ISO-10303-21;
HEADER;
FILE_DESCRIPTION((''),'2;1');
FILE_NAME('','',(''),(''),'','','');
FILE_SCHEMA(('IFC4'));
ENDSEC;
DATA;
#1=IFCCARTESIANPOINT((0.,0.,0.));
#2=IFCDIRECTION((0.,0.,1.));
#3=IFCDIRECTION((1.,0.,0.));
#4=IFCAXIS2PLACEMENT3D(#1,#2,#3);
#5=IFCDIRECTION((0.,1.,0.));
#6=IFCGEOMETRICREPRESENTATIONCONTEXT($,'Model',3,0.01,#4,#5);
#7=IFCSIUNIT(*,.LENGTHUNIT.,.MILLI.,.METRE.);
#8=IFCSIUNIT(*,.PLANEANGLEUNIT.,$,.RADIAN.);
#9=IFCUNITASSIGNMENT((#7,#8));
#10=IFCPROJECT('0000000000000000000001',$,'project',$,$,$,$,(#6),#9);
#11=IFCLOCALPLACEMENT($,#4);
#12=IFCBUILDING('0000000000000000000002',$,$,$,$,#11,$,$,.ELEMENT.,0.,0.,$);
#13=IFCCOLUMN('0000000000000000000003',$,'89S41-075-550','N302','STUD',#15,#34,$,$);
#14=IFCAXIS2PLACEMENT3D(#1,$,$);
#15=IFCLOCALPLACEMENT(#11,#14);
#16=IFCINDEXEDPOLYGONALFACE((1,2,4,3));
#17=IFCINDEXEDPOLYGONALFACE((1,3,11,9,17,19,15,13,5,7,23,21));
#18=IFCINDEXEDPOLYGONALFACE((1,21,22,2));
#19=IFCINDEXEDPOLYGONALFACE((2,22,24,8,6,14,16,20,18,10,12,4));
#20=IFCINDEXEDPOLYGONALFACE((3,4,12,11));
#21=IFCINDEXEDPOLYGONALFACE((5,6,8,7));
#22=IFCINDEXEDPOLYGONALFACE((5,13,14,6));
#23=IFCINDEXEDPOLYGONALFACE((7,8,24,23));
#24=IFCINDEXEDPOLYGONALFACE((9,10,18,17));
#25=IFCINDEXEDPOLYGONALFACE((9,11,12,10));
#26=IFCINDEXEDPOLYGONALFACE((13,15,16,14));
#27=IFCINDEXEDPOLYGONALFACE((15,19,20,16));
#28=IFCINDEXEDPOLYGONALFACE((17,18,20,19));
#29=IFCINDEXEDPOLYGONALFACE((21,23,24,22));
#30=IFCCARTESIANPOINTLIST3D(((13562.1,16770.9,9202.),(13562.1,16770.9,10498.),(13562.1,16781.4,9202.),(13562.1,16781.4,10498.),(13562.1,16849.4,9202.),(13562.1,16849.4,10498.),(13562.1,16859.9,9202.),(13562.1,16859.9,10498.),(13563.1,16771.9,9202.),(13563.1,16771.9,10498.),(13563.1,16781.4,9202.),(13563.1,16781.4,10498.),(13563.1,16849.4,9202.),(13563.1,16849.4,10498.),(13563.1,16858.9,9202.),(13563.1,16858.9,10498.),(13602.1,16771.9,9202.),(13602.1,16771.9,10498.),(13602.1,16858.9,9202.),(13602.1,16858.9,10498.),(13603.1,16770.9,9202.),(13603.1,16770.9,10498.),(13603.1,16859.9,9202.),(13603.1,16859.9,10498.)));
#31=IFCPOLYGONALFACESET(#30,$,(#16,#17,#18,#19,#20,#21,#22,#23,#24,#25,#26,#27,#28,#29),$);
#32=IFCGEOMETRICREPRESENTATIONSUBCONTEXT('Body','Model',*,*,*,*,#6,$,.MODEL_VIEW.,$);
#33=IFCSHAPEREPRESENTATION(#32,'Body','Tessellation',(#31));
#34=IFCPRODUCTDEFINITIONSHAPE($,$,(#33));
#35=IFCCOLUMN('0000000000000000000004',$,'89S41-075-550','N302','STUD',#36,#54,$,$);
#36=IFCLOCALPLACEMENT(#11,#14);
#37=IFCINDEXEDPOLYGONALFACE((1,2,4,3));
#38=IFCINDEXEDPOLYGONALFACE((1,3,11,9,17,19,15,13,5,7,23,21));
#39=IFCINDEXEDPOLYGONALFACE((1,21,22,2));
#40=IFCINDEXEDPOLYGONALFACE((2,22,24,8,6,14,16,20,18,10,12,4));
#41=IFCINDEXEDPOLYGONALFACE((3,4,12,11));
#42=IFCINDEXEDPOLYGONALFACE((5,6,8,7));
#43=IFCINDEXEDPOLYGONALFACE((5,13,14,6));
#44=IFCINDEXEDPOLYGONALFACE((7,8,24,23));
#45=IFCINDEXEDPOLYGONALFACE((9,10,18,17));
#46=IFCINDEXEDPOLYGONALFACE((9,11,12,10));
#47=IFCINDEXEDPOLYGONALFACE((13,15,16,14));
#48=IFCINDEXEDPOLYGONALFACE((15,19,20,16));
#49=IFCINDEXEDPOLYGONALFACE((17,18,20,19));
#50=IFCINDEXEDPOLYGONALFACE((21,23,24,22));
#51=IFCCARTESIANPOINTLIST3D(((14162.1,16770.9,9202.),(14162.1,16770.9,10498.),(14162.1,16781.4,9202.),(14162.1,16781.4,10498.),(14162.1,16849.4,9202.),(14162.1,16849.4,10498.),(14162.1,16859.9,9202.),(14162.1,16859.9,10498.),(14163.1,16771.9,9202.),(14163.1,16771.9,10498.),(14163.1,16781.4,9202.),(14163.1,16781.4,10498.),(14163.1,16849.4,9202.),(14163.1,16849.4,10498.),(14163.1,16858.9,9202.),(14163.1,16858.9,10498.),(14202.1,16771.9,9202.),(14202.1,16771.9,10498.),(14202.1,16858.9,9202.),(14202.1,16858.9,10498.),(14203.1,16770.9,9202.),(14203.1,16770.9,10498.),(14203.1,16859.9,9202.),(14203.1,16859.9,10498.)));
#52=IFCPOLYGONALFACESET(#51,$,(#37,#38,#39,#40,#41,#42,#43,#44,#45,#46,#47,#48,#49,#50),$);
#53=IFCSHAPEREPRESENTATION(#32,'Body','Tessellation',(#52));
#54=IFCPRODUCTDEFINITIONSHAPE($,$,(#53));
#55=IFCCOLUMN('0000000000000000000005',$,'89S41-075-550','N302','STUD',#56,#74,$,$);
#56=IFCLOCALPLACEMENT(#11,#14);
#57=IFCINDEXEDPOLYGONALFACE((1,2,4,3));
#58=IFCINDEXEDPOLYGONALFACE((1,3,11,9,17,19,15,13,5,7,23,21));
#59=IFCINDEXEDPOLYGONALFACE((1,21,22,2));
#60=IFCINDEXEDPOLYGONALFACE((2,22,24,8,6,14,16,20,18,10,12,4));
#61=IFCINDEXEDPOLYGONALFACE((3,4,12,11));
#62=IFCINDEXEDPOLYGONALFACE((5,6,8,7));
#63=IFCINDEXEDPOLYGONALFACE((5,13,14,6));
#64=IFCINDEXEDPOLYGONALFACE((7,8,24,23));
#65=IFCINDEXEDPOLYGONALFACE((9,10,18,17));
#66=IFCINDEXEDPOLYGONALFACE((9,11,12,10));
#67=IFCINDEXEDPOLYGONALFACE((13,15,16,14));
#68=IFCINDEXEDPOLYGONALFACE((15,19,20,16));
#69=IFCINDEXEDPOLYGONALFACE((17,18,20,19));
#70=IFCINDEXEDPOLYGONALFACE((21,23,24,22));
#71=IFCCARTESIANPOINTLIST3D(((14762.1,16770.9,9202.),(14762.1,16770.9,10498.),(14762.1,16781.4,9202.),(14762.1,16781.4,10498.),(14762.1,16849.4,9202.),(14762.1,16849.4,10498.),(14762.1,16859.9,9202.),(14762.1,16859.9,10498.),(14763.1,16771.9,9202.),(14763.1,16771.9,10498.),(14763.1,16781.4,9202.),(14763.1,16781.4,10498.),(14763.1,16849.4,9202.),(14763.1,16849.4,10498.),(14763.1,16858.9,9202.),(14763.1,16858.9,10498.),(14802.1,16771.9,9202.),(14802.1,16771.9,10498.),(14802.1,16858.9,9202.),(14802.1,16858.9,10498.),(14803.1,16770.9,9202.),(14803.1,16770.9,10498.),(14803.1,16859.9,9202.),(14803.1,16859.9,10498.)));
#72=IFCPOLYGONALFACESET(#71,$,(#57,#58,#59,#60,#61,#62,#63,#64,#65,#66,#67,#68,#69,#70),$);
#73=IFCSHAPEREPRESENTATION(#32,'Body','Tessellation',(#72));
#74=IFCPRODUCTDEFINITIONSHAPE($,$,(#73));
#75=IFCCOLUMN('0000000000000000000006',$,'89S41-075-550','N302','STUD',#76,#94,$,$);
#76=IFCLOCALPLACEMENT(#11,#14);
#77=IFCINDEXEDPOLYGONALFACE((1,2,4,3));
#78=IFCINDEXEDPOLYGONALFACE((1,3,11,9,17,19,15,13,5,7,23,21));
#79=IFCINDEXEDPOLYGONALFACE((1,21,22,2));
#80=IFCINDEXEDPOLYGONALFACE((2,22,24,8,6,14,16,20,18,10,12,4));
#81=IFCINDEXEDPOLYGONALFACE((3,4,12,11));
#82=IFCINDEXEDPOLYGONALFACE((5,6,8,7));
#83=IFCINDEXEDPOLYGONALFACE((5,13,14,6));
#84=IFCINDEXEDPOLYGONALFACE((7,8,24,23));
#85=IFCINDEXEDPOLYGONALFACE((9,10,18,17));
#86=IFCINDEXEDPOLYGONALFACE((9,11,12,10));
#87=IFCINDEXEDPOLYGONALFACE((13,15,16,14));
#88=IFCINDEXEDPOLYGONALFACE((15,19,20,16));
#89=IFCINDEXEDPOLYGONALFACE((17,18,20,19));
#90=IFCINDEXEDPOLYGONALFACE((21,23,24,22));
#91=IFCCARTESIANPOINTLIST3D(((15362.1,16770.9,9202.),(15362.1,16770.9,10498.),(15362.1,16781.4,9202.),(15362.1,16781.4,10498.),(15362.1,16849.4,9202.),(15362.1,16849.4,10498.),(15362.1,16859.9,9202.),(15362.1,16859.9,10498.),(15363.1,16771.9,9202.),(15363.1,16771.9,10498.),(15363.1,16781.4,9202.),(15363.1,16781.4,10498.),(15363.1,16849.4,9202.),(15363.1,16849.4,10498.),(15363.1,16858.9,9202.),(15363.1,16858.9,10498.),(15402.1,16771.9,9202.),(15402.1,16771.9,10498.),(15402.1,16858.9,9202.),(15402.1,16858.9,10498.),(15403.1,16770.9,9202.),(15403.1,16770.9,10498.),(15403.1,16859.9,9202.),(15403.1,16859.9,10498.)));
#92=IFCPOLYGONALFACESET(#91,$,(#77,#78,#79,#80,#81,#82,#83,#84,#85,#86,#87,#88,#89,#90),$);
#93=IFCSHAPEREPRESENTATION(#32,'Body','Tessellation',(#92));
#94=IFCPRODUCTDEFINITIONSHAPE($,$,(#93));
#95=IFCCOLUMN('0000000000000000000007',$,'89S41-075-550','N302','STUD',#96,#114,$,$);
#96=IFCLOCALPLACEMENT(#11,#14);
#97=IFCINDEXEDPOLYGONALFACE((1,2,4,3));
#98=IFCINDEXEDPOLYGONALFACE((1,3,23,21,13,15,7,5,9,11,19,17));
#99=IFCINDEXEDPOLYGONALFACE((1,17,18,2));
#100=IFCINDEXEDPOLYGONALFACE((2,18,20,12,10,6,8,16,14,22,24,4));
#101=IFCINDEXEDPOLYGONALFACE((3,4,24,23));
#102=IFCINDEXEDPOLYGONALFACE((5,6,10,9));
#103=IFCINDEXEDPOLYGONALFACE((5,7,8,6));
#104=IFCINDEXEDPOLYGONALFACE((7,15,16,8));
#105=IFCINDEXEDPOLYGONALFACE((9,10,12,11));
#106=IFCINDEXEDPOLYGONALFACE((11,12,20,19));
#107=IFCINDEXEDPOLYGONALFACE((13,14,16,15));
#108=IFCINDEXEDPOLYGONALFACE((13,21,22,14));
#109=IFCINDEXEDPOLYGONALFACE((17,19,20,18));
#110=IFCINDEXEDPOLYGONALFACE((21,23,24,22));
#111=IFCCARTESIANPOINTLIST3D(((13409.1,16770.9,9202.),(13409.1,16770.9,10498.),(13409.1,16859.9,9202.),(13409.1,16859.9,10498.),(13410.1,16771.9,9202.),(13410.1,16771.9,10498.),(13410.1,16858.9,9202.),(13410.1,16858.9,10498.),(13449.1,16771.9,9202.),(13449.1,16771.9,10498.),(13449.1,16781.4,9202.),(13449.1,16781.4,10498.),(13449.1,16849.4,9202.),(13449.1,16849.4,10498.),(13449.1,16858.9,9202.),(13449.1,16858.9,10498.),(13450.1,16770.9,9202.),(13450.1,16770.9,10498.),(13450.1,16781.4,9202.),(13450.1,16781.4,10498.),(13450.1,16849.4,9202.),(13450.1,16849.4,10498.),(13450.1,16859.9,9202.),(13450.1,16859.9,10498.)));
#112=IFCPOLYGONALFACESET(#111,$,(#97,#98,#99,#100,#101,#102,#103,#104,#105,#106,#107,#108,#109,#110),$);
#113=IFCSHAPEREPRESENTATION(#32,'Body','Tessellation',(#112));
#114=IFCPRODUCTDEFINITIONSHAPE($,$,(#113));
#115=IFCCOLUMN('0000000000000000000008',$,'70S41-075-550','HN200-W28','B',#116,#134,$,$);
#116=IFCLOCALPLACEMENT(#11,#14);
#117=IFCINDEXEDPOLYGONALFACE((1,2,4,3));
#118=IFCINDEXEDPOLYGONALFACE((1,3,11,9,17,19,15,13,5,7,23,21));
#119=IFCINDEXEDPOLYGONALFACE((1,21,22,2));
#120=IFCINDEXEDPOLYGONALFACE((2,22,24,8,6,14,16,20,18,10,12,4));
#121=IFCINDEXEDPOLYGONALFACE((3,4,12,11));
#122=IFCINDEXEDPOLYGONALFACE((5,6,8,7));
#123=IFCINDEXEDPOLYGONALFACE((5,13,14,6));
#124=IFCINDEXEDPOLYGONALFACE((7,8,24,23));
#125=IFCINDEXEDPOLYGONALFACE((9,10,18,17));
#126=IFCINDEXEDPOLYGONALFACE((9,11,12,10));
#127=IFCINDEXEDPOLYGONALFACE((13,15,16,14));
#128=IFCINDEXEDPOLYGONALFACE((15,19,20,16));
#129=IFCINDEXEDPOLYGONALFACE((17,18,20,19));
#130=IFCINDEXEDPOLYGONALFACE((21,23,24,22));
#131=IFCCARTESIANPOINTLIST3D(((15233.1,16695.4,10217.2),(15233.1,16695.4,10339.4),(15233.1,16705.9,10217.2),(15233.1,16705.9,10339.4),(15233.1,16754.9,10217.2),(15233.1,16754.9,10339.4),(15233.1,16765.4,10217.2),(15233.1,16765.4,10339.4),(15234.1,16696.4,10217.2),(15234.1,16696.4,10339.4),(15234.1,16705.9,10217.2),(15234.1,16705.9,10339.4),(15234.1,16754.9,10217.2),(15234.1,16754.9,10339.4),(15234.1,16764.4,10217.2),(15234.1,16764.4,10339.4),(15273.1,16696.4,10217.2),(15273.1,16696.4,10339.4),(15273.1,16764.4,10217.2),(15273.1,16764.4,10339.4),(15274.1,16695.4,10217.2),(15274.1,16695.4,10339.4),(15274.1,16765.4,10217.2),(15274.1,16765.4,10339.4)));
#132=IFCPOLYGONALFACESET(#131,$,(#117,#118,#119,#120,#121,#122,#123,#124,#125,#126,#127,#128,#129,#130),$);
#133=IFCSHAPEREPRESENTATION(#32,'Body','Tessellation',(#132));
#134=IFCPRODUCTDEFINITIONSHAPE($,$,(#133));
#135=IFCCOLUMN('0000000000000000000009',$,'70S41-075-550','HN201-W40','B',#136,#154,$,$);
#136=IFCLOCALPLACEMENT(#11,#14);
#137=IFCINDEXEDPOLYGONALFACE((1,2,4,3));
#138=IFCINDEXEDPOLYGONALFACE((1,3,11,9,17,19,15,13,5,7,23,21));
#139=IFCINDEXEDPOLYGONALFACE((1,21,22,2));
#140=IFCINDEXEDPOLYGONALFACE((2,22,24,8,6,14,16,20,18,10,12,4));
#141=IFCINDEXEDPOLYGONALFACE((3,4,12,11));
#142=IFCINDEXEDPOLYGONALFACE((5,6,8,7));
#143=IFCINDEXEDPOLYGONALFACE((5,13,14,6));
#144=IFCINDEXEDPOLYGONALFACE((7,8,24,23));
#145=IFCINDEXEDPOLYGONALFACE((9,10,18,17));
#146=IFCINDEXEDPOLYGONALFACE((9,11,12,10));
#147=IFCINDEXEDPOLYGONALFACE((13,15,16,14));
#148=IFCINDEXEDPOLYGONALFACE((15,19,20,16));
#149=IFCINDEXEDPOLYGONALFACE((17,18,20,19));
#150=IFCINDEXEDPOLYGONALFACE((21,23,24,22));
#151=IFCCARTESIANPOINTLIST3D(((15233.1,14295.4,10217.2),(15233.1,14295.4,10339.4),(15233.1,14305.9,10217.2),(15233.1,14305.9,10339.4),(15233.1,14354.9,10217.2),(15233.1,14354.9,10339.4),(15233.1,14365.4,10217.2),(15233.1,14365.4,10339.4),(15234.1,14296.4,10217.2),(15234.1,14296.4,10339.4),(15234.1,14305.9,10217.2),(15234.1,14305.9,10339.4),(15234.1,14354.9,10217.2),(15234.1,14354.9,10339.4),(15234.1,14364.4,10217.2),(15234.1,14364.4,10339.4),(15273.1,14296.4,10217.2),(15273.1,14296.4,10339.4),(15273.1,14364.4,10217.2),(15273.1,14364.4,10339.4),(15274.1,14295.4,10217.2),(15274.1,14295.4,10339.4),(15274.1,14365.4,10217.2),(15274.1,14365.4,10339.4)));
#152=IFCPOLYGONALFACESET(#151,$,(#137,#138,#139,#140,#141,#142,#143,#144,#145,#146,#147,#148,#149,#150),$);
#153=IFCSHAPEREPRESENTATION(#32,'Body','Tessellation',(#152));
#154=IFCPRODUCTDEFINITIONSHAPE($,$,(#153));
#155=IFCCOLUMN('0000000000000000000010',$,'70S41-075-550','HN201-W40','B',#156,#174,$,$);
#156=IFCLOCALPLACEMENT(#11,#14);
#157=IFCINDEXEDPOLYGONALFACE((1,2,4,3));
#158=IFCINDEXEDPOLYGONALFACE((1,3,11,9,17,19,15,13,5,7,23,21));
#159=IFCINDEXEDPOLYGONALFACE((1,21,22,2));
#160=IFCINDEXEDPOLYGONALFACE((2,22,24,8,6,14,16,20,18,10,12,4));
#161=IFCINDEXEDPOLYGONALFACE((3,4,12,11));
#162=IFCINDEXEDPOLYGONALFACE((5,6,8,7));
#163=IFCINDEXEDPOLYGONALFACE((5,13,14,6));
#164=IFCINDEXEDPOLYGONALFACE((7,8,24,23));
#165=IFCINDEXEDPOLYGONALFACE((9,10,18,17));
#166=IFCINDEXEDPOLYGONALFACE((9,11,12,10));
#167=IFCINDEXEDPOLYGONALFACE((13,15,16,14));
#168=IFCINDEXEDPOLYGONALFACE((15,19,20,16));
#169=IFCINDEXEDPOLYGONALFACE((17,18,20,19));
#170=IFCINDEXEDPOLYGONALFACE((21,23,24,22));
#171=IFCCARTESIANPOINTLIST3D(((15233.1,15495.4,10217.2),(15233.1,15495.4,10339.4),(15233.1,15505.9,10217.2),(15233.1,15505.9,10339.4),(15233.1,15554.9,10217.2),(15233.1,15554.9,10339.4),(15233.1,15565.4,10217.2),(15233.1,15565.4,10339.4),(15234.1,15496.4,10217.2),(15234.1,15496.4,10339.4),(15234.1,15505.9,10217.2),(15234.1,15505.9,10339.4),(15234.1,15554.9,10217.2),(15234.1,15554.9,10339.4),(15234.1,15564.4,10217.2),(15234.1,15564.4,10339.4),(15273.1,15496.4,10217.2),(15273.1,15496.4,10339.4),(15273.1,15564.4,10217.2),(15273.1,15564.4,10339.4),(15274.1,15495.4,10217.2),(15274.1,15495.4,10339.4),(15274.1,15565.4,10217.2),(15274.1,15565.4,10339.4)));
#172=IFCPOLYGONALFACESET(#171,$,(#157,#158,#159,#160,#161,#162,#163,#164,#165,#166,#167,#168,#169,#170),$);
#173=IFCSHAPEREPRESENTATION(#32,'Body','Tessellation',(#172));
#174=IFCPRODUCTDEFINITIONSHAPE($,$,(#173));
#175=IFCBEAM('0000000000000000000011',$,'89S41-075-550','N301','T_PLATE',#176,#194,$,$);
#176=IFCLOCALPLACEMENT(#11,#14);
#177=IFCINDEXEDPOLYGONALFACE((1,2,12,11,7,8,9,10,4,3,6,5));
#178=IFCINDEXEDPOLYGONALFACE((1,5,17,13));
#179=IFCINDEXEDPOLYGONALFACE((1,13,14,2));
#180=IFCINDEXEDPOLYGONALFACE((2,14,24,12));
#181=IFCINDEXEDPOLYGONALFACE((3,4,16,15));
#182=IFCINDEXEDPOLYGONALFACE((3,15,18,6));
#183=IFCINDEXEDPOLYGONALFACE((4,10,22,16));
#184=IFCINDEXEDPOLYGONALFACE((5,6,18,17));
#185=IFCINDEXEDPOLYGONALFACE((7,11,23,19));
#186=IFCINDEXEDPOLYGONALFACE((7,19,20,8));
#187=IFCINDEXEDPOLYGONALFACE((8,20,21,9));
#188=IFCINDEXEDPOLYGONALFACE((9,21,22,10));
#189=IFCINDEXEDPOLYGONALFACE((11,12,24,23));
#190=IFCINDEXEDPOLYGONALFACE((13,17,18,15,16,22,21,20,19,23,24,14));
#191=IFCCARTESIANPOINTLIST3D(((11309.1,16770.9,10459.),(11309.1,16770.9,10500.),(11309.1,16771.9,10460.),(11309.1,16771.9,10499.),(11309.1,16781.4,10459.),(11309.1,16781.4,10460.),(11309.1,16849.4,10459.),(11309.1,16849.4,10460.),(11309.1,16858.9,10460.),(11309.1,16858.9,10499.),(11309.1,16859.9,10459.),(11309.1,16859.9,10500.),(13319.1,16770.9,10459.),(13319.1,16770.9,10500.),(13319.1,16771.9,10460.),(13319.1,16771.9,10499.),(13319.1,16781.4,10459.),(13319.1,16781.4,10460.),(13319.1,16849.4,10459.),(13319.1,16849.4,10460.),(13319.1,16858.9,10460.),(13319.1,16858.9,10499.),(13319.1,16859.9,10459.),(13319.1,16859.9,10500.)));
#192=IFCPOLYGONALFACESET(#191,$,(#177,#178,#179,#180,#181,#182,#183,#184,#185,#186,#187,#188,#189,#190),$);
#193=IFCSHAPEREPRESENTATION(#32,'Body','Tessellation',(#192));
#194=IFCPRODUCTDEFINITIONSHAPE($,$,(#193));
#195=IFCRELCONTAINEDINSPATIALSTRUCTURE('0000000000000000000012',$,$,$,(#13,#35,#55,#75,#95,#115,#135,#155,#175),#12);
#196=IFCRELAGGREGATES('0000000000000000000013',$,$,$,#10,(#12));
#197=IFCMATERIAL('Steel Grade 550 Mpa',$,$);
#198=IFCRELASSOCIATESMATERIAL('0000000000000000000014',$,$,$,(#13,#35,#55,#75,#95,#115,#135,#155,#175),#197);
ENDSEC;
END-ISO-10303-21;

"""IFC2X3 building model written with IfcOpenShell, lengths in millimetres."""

from ifc_helpers import new_model, si_unit, direction, frame, origin, origin_with_axes, origin_2d_with_axis, place, context, subcontext, project, spatial, c_section, extrude, source, transform, mapped, material, element, save


model = new_model("IFC2X3")

# Units and contexts
model_context = context("Model", 3, precision=0.01, world=origin_with_axes(), true_north=direction((0.0, 1.0, 0.0)))
body_context = subcontext(model_context, "Body", "Model", "MODEL_VIEW")
ifc_project = project(units=[si_unit("LENGTHUNIT", "METRE", prefix="MILLI"), si_unit("PLANEANGLEUNIT", "RADIAN")], contexts=[model_context])

# Building
building_placement = place(None, origin_with_axes())
building = spatial("IfcBuilding", under=ifc_project, at=building_placement, CompositionType="ELEMENT", ElevationOfRefHeight=0.0, ElevationOfTerrain=0.0)

# Columns
ifc_material = material(Name="Steel Grade 550 Mpa")
shared_shape_1 = source(origin(), body_context, "Body", "SweptSolid", [
    extrude(c_section(Depth=89.0, Width=41.0, WallThickness=1.0, Girth=10.5, at=origin_2d_with_axis()), origin_with_axes(), (0.0, 0.0, 1.0), 1296.0),
])
column_1_placement = place(None, frame((13582.6, 16815.4, 9202.0), z_axis=(0.0, 0.0, 1.0), x_axis=(-1.0, 0.0, 0.0)))
element("IfcColumn", 1, at=column_1_placement, inside=building, material=ifc_material, Name="89S41-075-550", Description="N302", ObjectType="STUD", context=body_context, shape_type="MappedRepresentation", body=[
    mapped(shared_shape_1, transform((0.0, 0.0, 0.0), scale=1.0)),
])
shared_shape_2 = source(origin(), body_context, "Body", "SweptSolid", [
    extrude(c_section(Depth=89.0, Width=41.0, WallThickness=1.0, Girth=10.5, at=origin_2d_with_axis()), origin_with_axes(), (0.0, 0.0, 1.0), 1296.0),
])
column_2_placement = place(None, frame((14182.6, 16815.4, 9202.0), z_axis=(0.0, 0.0, 1.0), x_axis=(-1.0, 0.0, 0.0)))
element("IfcColumn", 2, at=column_2_placement, inside=building, material=ifc_material, Name="89S41-075-550", Description="N302", ObjectType="STUD", context=body_context, shape_type="MappedRepresentation", body=[
    mapped(shared_shape_2, transform((0.0, 0.0, 0.0), scale=1.0)),
])
shared_shape_3 = source(origin(), body_context, "Body", "SweptSolid", [
    extrude(c_section(Depth=89.0, Width=41.0, WallThickness=1.0, Girth=10.5, at=origin_2d_with_axis()), origin_with_axes(), (0.0, 0.0, 1.0), 1296.0),
])
column_3_placement = place(None, frame((14782.6, 16815.4, 9202.0), z_axis=(0.0, 0.0, 1.0), x_axis=(-1.0, 0.0, 0.0)))
element("IfcColumn", 3, at=column_3_placement, inside=building, material=ifc_material, Name="89S41-075-550", Description="N302", ObjectType="STUD", context=body_context, shape_type="MappedRepresentation", body=[
    mapped(shared_shape_3, transform((0.0, 0.0, 0.0), scale=1.0)),
])
shared_shape_4 = source(origin(), body_context, "Body", "SweptSolid", [
    extrude(c_section(Depth=89.0, Width=41.0, WallThickness=1.0, Girth=10.5, at=origin_2d_with_axis()), origin_with_axes(), (0.0, 0.0, 1.0), 1296.0),
])
column_4_placement = place(None, frame((15382.6, 16815.4, 9202.0), z_axis=(0.0, 0.0, 1.0), x_axis=(-1.0, 0.0, 0.0)))
element("IfcColumn", 4, at=column_4_placement, inside=building, material=ifc_material, Name="89S41-075-550", Description="N302", ObjectType="STUD", context=body_context, shape_type="MappedRepresentation", body=[
    mapped(shared_shape_4, transform((0.0, 0.0, 0.0), scale=1.0)),
])
shared_shape_5 = source(origin(), body_context, "Body", "SweptSolid", [
    extrude(c_section(Depth=89.0, Width=41.0, WallThickness=1.0, Girth=10.5, at=origin_2d_with_axis()), origin_with_axes(), (0.0, 0.0, 1.0), 1296.0),
])
column_5_placement = place(None, frame((13429.6, 16815.4, 9202.0), z_axis=(0.0, 0.0, 1.0), x_axis=(1.0, 0.0, 0.0)))
element("IfcColumn", 5, at=column_5_placement, inside=building, material=ifc_material, Name="89S41-075-550", Description="N302", ObjectType="STUD", context=body_context, shape_type="MappedRepresentation", body=[
    mapped(shared_shape_5, transform((0.0, 0.0, 0.0), scale=1.0)),
])
shared_shape_6 = source(origin(), body_context, "Body", "SweptSolid", [
    extrude(c_section(Depth=70.0, Width=41.0, WallThickness=1.0, Girth=10.5, at=origin_2d_with_axis()), origin_with_axes(), (0.0, 0.0, 1.0), 122.1),
])
column_6_placement = place(None, frame((15253.6, 16730.4, 10339.4), z_axis=(0.0, 0.0, -1.0), x_axis=(-1.0, 0.0, 0.0)))
element("IfcColumn", 6, at=column_6_placement, inside=building, material=ifc_material, Name="70S41-075-550", Description="HN200-W28", ObjectType="B", context=body_context, shape_type="MappedRepresentation", body=[
    mapped(shared_shape_6, transform((0.0, 0.0, 0.0), scale=1.0)),
])
shared_shape_7 = source(origin(), body_context, "Body", "SweptSolid", [
    extrude(c_section(Depth=70.0, Width=41.0, WallThickness=1.0, Girth=10.5, at=origin_2d_with_axis()), origin_with_axes(), (0.0, 0.0, 1.0), 122.1),
])
column_7_placement = place(None, frame((15253.6, 14330.4, 10339.4), z_axis=(0.0, 0.0, -1.0), x_axis=(-1.0, 0.0, 0.0)))
element("IfcColumn", 7, at=column_7_placement, inside=building, material=ifc_material, Name="70S41-075-550", Description="HN201-W40", ObjectType="B", context=body_context, shape_type="MappedRepresentation", body=[
    mapped(shared_shape_7, transform((0.0, 0.0, 0.0), scale=1.0)),
])
shared_shape_8 = source(origin(), body_context, "Body", "SweptSolid", [
    extrude(c_section(Depth=70.0, Width=41.0, WallThickness=1.0, Girth=10.5, at=origin_2d_with_axis()), origin_with_axes(), (0.0, 0.0, 1.0), 122.1),
])
column_8_placement = place(None, frame((15253.6, 15530.4, 10339.4), z_axis=(0.0, 0.0, -1.0), x_axis=(-1.0, 0.0, 0.0)))
element("IfcColumn", 8, at=column_8_placement, inside=building, material=ifc_material, Name="70S41-075-550", Description="HN201-W40", ObjectType="B", context=body_context, shape_type="MappedRepresentation", body=[
    mapped(shared_shape_8, transform((0.0, 0.0, 0.0), scale=1.0)),
])

# Beam
shared_shape_9 = source(origin(), body_context, "Body", "SweptSolid", [
    extrude(c_section(Depth=89.0, Width=41.0, WallThickness=1.0, Girth=10.5, at=origin_2d_with_axis()), origin_with_axes(), (0.0, 0.0, 1.0), 2010.0),
])
beam_1_placement = place(None, frame((13319.1, 16815.4, 10479.5), z_axis=(-1.0, 0.0, 0.0), x_axis=(0.0, 0.0, -1.0)))
element("IfcBeam", 9, at=beam_1_placement, inside=building, material=ifc_material, Name="89S41-075-550", Description="N301", ObjectType="T_PLATE", context=body_context, shape_type="MappedRepresentation", body=[
    mapped(shared_shape_9, transform((0.0, 0.0, 0.0), scale=1.0)),
])

save(model, "model.ifc")
